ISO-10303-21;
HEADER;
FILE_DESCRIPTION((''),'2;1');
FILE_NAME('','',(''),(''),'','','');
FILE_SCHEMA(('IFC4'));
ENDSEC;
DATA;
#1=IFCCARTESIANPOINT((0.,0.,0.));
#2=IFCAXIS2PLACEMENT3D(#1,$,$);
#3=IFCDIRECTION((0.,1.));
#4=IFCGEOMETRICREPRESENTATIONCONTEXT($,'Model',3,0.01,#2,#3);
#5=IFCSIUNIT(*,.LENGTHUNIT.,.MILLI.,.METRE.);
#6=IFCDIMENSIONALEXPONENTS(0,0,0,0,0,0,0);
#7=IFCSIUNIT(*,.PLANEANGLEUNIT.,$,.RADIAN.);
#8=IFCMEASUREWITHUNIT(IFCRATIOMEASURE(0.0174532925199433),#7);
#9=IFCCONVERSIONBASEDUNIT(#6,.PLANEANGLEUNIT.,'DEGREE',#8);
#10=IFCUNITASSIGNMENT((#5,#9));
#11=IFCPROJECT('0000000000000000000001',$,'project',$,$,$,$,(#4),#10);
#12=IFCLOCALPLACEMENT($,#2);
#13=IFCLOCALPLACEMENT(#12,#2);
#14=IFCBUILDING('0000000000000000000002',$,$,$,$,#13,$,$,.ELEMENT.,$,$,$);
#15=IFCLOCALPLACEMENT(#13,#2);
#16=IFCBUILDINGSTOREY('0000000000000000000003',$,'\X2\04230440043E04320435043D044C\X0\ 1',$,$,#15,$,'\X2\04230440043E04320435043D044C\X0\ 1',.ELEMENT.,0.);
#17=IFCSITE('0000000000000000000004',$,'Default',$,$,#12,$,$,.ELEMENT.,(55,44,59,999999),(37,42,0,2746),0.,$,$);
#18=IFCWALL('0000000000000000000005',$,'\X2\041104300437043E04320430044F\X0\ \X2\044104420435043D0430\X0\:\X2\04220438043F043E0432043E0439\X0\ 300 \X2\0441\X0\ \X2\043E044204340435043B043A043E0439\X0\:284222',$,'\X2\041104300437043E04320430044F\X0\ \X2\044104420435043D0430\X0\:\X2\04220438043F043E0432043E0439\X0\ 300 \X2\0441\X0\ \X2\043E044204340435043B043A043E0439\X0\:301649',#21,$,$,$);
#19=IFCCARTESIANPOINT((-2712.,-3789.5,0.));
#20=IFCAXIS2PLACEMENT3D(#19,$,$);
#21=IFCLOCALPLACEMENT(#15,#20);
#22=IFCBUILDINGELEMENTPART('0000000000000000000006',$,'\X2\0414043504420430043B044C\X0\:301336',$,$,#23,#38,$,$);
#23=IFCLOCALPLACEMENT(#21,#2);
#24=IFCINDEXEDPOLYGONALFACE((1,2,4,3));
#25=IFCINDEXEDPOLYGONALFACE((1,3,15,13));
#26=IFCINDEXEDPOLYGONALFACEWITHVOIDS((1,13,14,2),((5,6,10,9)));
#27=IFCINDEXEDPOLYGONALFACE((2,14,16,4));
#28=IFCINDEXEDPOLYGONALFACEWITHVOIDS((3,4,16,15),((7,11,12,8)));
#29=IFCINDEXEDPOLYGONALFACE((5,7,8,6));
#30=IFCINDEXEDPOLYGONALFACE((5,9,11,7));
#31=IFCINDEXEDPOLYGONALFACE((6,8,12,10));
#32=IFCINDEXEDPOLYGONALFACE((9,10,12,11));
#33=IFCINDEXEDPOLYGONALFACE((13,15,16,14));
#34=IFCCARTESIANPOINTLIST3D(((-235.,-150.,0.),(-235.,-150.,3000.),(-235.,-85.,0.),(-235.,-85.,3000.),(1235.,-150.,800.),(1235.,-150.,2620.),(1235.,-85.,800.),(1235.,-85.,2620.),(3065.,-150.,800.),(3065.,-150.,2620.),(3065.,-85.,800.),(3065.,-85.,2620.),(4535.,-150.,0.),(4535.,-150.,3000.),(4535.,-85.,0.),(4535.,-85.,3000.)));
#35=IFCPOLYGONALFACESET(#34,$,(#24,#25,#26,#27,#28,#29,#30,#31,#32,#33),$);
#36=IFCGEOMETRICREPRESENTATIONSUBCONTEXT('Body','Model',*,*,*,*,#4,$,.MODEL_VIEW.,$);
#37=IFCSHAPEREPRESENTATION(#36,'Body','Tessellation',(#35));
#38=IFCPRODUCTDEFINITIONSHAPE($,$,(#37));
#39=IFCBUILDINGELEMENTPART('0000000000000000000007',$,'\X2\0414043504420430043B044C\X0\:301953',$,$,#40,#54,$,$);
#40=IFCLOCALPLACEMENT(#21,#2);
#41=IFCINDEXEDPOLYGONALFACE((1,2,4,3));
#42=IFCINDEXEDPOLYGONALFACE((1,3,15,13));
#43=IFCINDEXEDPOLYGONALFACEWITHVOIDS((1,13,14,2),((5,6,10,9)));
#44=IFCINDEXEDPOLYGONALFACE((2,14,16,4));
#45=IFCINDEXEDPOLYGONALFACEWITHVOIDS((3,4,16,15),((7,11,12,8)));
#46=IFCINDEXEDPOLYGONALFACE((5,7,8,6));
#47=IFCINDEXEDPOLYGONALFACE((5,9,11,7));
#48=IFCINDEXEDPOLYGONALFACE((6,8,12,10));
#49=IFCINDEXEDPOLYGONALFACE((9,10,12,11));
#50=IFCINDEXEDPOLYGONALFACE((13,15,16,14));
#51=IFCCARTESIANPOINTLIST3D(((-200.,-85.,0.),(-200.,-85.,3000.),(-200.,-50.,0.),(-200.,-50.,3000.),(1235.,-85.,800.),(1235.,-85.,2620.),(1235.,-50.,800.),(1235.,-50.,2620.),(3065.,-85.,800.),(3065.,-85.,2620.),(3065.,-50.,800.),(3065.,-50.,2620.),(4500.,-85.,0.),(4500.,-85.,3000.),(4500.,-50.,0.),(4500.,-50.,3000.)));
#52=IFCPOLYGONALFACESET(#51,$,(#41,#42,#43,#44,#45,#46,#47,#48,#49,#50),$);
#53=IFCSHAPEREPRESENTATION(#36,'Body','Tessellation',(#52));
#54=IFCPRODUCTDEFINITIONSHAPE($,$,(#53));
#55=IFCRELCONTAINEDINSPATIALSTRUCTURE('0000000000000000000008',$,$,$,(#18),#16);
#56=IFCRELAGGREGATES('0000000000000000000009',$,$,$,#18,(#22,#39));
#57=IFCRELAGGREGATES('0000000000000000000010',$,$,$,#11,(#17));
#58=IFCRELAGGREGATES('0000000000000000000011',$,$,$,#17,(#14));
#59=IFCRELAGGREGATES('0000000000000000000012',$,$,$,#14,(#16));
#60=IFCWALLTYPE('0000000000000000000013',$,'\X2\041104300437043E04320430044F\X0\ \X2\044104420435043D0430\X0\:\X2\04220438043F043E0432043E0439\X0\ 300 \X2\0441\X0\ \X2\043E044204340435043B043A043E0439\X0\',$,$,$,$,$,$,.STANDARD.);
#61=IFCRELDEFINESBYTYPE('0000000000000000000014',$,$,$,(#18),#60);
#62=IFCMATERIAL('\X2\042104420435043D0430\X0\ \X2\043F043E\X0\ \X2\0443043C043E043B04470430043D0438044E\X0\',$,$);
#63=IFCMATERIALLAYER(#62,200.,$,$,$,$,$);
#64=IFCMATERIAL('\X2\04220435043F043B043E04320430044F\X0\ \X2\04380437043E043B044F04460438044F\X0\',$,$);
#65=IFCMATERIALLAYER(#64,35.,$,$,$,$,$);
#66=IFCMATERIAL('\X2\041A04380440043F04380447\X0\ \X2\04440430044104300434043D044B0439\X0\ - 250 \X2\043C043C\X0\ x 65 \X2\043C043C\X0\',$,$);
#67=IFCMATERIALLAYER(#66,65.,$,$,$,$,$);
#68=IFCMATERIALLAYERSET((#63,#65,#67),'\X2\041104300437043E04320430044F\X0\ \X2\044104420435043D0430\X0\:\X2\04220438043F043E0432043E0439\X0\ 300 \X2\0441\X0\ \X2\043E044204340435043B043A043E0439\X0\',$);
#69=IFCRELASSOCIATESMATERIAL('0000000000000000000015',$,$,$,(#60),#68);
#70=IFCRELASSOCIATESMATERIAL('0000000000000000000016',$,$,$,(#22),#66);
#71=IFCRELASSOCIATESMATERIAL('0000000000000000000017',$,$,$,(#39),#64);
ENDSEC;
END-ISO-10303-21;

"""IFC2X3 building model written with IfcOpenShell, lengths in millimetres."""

from ifc_helpers import new_model, entity, si_unit, converted_unit, direction, frame, frame_2d, origin, place, context, subcontext, project, spatial, rectangle, extrude, material, layer, layer_set, type_object, element, aggregate, save


model = new_model("IFC2X3")

# Units and contexts
model_context = context("Model", 3, precision=0.01, world=origin(), true_north=direction((0.0, 1.0)))
body_context = subcontext(model_context, "Body", "Model", "MODEL_VIEW")
ifc_project = project(units=[si_unit("LENGTHUNIT", "METRE", prefix="MILLI"), converted_unit("PLANEANGLEUNIT", "DEGREE", entity("IfcRatioMeasure", 0.0174532925199433), si_unit("PLANEANGLEUNIT", "RADIAN"), dimensions=[0, 0, 0, 0, 0, 0, 0])], contexts=[model_context])

# Site, building, storey
site_placement = place(None, origin())
site = spatial("IfcSite", under=ifc_project, at=site_placement, Name="Default", CompositionType="ELEMENT", RefLatitude=(55, 44, 59, 999999), RefLongitude=(37, 42, 0, 2746), RefElevation=0.0)
building_placement = place(site_placement, origin())
building = spatial("IfcBuilding", under=site, at=building_placement, CompositionType="ELEMENT")
storey_placement = place(building_placement, origin())
storey = spatial("IfcBuildingStorey", under=building, at=storey_placement, Name="Уровень 1", LongName="Уровень 1", CompositionType="ELEMENT", Elevation=0.0)

# Shared definitions
ifc_material_1 = material(Name="Стена по умолчанию")
ifc_layer_1 = layer(ifc_material_1, 200.0)
ifc_material_2 = material(Name="Тепловая изоляция")
ifc_layer_2 = layer(ifc_material_2, 35.0)
ifc_material_3 = material(Name="Кирпич фасадный - 250 мм x 65 мм")
ifc_layer_3 = layer(ifc_material_3, 65.0)
ifc_layer_set_1 = layer_set([ifc_layer_1, ifc_layer_2, ifc_layer_3], Name="Базовая стена:Типовой 300 с отделкой")
wall_type_1 = type_object("IfcWallType", Name="Базовая стена:Типовой 300 с отделкой", PredefinedType="STANDARD", material=ifc_layer_set_1)

# Wall, building element parts, openings
wall_1_placement = place(storey_placement, frame((-2712.0, -3789.5, 0.0)))
wall_1 = element("IfcWall", 1, at=wall_1_placement, inside=storey, type_object=wall_type_1, Name="Базовая стена:Типовой 300 с отделкой:284222", ObjectType="Базовая стена:Типовой 300 с отделкой:301649")
building_element_part_1_placement = place(wall_1_placement, origin())
building_element_part_1 = element("IfcBuildingElementPart", 2, at=building_element_part_1_placement, material=ifc_material_3, Name="Деталь:301336", context=body_context, shape_type="SweptSolid", body=[
    extrude(rectangle(XDim=65.0, YDim=4770.0, at=frame_2d((0.0, 0.0), x_axis=(1.0, 0.0))), frame((2150.0, -117.5, 0.0), z_axis=(0.0, 0.0, 1.0), x_axis=(0.0, 1.0, 0.0)), (0.0, 0.0, 1.0), 3000.0),
])
opening_1_placement = place(wall_1_placement, origin())
opening_1 = element("IfcOpeningElement", 3, at=opening_1_placement, cuts=building_element_part_1, ObjectType="Opening", context=body_context, shape_type="SweptSolid", body=[
    extrude(rectangle(XDim=1820.0, YDim=1830.0, at=frame_2d((0.0, 0.0), x_axis=(1.0, 0.0))), frame((2150.0, -150.0, 1710.0), z_axis=(0.0, 1.0, 0.0), x_axis=(0.0, 0.0, 1.0)), (0.0, 0.0, 1.0), 65.0),
])
building_element_part_2_placement = place(wall_1_placement, origin())
building_element_part_2 = element("IfcBuildingElementPart", 4, at=building_element_part_2_placement, material=ifc_material_2, Name="Деталь:301953", context=body_context, shape_type="SweptSolid", body=[
    extrude(rectangle(XDim=35.0, YDim=4700.0, at=frame_2d((0.0, 0.0), x_axis=(1.0, 0.0))), frame((2150.0, -67.5, 0.0), z_axis=(0.0, 0.0, 1.0), x_axis=(0.0, 1.0, 0.0)), (0.0, 0.0, 1.0), 3000.0),
])
opening_2_placement = place(wall_1_placement, origin())
opening_2 = element("IfcOpeningElement", 5, at=opening_2_placement, cuts=building_element_part_2, ObjectType="Opening", context=body_context, shape_type="SweptSolid", body=[
    extrude(rectangle(XDim=1820.0, YDim=1830.0, at=frame_2d((0.0, 0.0), x_axis=(1.0, 0.0))), frame((2150.0, -85.0, 1710.0), z_axis=(0.0, 1.0, 0.0), x_axis=(0.0, 0.0, 1.0)), (0.0, 0.0, 1.0), 35.0),
])
aggregate(wall_1, [building_element_part_1, opening_1, building_element_part_2, opening_2])

save(model, "model.ifc")
